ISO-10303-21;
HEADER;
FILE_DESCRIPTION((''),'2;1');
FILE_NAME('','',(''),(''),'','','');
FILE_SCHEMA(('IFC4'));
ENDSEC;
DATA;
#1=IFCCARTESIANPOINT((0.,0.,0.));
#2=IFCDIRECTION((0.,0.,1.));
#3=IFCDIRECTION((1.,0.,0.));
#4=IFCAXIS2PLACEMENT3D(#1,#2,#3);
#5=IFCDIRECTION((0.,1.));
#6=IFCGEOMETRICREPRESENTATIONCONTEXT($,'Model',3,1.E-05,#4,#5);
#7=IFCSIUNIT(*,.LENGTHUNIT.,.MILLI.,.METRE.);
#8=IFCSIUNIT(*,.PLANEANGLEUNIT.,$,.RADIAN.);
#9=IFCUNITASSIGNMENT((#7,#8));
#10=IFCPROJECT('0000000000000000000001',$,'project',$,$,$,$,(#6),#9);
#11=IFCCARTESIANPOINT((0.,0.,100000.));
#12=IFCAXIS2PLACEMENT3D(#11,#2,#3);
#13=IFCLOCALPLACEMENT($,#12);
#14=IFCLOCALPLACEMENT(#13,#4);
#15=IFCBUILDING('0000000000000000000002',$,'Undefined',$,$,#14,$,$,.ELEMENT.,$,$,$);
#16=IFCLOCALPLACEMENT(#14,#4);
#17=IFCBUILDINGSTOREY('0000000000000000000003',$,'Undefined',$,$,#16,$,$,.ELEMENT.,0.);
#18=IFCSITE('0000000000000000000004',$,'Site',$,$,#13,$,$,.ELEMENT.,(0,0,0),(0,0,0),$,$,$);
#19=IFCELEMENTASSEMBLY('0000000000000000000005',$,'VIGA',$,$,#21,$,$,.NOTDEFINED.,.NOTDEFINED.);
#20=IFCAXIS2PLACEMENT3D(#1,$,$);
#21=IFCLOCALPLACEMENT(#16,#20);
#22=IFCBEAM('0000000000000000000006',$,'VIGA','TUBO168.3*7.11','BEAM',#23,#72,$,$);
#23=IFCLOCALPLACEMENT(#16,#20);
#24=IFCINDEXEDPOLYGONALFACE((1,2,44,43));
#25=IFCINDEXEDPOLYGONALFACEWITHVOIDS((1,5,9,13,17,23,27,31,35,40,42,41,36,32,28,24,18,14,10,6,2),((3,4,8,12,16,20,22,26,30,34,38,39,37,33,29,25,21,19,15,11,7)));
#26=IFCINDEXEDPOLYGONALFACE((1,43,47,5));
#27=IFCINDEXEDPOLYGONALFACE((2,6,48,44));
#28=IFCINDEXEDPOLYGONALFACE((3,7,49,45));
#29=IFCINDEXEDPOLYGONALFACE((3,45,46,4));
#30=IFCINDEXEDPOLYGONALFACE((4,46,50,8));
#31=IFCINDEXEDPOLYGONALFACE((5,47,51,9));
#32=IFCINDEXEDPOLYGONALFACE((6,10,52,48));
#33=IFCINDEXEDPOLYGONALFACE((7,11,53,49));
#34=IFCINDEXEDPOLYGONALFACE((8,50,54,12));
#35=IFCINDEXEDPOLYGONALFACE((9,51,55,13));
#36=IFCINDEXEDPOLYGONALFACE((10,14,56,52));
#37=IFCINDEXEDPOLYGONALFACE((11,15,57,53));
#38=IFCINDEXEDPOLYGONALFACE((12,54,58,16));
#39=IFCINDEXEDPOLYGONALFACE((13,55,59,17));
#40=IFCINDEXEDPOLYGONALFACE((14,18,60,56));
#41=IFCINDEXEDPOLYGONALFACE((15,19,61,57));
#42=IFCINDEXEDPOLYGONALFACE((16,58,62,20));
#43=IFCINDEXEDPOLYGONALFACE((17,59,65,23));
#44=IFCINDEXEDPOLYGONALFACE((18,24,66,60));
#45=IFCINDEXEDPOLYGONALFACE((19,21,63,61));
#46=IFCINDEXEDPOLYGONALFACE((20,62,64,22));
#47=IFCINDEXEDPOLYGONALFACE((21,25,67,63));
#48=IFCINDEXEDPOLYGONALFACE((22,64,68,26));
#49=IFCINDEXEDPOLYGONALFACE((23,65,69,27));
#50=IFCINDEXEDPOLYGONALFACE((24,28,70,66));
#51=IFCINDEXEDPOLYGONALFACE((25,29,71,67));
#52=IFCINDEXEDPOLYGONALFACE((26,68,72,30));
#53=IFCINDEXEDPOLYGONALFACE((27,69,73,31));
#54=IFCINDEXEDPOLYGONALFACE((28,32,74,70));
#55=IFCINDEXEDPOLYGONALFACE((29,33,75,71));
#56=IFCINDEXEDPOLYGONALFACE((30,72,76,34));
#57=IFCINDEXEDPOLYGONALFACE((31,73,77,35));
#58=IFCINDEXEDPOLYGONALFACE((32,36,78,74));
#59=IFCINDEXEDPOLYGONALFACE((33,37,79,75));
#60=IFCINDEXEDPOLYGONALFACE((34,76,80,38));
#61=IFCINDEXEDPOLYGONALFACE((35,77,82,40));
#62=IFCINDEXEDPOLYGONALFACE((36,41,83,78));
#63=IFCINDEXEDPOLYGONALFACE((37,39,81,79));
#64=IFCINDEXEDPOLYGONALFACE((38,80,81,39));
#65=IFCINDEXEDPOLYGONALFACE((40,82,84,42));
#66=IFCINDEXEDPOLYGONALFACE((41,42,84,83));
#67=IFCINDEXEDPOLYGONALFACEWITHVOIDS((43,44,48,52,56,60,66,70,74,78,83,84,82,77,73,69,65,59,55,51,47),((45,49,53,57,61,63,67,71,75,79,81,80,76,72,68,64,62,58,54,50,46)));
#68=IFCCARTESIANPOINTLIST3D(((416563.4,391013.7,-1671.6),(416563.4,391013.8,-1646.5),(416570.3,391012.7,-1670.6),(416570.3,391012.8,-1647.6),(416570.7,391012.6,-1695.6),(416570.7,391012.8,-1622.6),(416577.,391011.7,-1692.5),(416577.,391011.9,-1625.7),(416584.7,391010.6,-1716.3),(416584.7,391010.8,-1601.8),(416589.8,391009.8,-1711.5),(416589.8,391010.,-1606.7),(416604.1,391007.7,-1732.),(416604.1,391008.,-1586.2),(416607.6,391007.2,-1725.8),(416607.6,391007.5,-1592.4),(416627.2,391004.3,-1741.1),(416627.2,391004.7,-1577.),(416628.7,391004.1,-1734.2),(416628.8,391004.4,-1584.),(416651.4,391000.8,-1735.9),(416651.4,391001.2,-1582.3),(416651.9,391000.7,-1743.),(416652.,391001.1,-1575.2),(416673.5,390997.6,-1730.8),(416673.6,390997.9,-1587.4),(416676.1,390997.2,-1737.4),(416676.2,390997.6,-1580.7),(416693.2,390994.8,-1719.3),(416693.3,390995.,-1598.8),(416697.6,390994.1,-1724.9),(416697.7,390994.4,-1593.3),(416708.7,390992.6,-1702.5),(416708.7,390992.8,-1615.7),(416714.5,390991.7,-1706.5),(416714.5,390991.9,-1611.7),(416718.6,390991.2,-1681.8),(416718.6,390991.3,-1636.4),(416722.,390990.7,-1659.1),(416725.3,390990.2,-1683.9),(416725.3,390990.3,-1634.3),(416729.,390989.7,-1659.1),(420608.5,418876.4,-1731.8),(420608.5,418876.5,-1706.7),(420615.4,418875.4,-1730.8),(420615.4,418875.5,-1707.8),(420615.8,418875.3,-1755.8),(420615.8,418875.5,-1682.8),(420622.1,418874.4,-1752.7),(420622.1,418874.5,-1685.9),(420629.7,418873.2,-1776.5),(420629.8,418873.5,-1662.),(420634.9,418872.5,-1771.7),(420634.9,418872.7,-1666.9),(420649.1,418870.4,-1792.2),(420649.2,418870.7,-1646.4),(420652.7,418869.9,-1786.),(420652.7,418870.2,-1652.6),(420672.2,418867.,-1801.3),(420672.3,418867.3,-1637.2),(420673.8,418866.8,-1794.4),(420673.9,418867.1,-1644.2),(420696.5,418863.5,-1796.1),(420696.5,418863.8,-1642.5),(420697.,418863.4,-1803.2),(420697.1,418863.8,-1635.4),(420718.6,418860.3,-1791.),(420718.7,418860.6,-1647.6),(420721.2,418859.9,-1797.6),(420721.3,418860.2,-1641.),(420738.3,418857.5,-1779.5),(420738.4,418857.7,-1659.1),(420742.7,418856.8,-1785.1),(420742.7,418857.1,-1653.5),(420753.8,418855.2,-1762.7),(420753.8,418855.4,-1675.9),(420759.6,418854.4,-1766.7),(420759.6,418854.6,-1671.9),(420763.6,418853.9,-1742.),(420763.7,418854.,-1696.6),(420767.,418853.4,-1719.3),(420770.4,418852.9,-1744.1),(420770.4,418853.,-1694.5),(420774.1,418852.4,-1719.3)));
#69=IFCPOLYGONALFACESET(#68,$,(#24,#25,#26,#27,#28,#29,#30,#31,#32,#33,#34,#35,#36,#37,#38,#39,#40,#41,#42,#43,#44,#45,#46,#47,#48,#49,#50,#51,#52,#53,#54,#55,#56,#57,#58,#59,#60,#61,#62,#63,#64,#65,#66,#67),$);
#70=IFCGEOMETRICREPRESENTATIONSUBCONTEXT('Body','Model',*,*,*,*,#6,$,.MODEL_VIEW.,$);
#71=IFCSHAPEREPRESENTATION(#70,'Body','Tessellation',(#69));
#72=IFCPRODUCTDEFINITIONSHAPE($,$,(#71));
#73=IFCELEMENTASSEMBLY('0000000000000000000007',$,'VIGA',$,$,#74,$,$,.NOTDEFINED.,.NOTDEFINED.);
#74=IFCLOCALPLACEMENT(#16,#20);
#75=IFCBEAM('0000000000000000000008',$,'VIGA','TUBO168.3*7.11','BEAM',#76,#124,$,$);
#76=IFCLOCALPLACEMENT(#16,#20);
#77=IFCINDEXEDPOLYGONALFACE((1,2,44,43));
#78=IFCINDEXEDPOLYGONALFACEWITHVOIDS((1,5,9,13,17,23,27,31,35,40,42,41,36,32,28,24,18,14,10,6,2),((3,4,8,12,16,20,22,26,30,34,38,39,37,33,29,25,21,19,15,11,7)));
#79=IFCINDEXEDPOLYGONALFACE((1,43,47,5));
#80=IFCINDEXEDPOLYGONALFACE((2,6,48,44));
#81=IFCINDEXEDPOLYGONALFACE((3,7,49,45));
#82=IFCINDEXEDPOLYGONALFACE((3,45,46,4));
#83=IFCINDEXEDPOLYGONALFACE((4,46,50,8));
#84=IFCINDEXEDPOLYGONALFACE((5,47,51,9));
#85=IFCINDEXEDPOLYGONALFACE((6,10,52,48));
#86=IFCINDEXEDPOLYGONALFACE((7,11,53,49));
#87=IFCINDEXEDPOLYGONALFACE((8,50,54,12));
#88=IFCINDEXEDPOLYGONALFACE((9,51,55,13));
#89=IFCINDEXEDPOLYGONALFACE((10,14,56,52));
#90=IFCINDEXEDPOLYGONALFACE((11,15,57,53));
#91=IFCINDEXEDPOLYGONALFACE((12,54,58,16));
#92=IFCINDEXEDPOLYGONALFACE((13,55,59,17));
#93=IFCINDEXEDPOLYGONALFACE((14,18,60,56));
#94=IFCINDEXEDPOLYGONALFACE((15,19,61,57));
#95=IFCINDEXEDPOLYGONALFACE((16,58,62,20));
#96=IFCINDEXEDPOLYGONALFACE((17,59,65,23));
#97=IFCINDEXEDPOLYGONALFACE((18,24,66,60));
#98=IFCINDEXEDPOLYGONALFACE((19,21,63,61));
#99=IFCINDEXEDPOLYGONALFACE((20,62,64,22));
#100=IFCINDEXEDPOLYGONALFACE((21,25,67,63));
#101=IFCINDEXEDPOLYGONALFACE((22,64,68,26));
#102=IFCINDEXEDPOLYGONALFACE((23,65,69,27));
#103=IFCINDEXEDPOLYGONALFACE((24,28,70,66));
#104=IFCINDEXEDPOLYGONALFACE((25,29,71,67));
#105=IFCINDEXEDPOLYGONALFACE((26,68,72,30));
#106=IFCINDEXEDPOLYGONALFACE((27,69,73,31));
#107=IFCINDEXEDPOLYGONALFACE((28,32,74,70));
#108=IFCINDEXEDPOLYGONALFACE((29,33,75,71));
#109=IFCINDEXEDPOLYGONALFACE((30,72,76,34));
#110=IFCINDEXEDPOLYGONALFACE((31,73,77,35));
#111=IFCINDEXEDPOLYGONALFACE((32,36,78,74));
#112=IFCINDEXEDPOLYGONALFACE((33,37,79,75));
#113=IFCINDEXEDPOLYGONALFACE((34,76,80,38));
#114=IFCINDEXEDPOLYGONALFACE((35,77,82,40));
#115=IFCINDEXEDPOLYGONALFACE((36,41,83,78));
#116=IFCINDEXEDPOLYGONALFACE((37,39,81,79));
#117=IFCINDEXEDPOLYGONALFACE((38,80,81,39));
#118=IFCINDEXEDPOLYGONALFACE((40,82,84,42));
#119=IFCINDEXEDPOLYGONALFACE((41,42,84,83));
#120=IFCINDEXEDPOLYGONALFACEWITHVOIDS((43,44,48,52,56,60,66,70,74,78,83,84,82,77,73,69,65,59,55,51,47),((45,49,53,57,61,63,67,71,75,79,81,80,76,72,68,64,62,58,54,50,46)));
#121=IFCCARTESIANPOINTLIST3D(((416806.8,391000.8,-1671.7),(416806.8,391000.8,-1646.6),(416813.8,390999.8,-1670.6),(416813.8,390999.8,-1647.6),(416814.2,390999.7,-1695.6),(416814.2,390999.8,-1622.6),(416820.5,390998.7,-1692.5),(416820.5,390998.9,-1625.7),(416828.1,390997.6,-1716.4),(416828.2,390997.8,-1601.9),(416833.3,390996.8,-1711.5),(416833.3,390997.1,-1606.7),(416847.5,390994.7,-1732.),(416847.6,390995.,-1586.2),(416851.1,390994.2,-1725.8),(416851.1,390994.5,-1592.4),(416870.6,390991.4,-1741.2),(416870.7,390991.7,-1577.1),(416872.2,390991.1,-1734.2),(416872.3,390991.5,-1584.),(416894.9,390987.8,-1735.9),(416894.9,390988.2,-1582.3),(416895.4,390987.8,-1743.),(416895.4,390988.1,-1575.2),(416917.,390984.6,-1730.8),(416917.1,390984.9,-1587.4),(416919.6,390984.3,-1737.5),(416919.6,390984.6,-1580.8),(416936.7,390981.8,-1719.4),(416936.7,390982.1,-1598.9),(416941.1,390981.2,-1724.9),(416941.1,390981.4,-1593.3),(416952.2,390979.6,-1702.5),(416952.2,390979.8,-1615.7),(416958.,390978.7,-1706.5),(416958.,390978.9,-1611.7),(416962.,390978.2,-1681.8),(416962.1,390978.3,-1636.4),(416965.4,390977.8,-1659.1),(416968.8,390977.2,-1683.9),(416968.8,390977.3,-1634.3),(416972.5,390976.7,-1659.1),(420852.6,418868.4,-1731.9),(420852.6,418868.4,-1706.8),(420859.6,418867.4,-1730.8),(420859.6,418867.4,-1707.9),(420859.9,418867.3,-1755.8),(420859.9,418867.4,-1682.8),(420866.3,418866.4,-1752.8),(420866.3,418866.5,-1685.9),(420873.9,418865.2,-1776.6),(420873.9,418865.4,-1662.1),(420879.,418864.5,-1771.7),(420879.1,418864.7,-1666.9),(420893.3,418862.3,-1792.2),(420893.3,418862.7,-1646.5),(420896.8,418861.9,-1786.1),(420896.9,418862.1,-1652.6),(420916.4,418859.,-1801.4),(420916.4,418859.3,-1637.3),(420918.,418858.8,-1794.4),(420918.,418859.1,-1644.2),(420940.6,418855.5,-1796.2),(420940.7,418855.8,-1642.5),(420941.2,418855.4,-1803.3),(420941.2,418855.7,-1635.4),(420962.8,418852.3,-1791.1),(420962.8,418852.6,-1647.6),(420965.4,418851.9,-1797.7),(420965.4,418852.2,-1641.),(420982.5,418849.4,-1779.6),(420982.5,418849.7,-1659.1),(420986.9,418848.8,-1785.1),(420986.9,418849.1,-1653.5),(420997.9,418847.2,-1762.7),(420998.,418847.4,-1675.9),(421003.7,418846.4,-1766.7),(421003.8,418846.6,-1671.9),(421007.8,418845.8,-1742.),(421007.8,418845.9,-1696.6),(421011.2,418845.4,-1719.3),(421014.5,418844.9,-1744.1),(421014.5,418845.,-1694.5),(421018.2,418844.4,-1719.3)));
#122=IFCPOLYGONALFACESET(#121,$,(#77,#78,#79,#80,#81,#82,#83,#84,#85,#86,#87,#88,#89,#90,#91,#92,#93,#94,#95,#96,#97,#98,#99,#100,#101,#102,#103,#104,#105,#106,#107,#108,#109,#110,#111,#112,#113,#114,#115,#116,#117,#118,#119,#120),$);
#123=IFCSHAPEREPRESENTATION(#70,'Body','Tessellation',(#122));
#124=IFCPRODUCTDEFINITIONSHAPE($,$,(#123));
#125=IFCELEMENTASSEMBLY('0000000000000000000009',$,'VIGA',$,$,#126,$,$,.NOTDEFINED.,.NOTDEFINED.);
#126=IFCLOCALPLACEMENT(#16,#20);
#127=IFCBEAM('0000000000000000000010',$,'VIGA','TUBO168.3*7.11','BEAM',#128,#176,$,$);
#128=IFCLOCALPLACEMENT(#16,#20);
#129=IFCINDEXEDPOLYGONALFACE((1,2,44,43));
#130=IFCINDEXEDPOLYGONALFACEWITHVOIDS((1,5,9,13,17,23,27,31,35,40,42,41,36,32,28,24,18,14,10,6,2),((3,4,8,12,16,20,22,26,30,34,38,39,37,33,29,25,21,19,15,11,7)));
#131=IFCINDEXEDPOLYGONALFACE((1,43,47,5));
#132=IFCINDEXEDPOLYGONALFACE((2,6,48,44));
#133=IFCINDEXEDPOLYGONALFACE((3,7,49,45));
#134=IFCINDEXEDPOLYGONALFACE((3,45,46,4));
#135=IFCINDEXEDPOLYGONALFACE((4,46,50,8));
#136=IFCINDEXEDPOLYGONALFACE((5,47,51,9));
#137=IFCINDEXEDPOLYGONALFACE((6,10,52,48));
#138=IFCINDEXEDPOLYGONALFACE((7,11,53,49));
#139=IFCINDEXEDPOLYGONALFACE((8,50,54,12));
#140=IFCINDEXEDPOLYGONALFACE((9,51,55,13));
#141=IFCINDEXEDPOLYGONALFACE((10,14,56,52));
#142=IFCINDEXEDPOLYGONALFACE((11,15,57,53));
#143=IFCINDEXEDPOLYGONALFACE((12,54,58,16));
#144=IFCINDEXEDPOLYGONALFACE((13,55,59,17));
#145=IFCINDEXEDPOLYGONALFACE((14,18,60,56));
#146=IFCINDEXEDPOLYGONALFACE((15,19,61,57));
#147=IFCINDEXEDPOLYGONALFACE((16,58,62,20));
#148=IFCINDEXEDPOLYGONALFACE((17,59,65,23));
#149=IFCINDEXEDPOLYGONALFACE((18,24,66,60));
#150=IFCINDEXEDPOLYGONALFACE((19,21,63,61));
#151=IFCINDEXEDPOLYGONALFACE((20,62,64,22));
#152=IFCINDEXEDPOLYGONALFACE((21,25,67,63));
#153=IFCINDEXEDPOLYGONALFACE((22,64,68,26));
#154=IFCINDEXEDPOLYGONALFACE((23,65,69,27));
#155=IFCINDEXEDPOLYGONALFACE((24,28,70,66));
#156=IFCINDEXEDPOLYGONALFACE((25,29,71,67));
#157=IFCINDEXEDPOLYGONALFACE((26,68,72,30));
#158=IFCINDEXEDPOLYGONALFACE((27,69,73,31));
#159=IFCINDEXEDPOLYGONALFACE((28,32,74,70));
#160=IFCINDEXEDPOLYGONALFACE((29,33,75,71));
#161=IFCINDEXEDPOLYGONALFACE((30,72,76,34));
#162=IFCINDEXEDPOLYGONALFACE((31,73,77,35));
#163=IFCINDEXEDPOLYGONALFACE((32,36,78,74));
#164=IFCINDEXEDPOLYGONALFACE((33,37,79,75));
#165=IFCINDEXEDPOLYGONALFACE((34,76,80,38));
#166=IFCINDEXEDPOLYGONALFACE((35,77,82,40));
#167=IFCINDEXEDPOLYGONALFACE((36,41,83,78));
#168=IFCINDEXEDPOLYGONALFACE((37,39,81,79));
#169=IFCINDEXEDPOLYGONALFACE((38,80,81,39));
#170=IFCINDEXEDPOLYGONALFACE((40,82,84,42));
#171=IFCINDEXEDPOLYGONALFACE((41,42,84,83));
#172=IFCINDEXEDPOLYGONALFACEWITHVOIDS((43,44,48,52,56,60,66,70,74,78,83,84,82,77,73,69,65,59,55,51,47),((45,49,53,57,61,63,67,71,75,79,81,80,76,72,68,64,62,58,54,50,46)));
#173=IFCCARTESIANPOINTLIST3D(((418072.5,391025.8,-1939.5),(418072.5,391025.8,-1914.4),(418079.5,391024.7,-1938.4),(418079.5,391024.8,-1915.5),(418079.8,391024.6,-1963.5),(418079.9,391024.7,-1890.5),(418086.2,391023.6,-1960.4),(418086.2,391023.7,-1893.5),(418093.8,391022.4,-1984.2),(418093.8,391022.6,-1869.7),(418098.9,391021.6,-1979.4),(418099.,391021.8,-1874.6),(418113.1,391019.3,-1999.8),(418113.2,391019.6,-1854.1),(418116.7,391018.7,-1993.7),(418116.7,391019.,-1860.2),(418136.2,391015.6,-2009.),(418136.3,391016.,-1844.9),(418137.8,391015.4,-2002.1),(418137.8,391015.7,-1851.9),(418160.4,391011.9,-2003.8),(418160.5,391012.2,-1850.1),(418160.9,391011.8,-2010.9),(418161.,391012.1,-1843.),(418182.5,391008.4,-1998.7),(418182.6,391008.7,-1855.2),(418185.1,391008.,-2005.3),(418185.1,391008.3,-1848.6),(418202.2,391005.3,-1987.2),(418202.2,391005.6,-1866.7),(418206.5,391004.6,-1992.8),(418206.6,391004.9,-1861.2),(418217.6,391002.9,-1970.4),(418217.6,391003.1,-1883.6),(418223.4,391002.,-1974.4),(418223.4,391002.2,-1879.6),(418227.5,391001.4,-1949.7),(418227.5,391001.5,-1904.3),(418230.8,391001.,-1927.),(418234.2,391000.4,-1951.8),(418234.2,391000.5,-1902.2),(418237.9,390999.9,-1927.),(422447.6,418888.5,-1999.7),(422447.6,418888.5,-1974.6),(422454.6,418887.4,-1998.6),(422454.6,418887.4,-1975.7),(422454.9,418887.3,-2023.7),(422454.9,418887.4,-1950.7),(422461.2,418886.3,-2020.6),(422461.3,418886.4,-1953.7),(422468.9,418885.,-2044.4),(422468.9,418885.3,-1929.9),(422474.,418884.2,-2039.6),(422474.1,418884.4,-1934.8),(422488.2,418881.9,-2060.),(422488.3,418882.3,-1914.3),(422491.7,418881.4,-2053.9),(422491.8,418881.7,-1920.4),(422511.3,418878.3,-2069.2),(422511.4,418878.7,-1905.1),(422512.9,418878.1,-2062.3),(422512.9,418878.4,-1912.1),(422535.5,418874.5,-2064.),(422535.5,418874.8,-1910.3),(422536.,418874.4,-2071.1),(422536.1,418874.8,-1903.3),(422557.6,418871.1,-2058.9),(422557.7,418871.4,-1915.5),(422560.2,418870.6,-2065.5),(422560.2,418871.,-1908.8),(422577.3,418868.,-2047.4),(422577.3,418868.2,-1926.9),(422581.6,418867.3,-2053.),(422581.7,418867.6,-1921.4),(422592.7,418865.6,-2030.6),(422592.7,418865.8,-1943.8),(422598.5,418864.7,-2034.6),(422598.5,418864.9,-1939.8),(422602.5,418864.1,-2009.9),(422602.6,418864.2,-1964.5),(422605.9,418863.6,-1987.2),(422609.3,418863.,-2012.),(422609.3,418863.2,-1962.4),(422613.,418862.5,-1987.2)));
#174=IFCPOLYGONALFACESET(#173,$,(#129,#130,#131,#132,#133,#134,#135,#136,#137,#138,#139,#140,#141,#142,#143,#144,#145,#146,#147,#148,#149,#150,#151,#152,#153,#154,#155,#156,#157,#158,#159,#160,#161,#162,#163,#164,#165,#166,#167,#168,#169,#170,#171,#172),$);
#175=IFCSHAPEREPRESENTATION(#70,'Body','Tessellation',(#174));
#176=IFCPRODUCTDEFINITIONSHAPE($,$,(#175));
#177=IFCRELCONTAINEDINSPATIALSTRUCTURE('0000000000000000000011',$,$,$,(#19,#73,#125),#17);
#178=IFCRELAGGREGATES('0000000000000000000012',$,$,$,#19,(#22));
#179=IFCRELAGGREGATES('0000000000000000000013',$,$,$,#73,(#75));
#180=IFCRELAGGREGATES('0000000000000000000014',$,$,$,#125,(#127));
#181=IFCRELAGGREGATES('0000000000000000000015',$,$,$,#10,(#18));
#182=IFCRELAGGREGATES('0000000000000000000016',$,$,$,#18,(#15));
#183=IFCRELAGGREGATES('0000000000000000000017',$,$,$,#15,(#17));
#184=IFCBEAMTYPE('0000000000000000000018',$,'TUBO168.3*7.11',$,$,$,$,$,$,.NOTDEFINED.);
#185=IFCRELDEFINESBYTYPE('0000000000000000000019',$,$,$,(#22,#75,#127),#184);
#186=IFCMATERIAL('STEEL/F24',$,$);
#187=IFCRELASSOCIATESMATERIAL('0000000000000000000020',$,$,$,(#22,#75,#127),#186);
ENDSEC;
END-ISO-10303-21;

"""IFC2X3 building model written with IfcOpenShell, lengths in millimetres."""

from ifc_helpers import new_model, si_unit, direction, frame, origin_with_axes, origin_2d_with_axis, place, context, subcontext, project, spatial, hollow_circle, extrude, material, type_object, element, aggregate, save


model = new_model("IFC2X3")

# Units and contexts
model_context = context("Model", 3, precision=1e-05, world=origin_with_axes(), true_north=direction((0.0, 1.0)))
body_context = subcontext(model_context, "Body", "Model", "MODEL_VIEW")
ifc_project = project(units=[si_unit("LENGTHUNIT", "METRE", prefix="MILLI"), si_unit("PLANEANGLEUNIT", "RADIAN")], contexts=[model_context])

# Site, building, storey
site_placement = place(None, frame((0.0, 0.0, 100000.0), z_axis=(0.0, 0.0, 1.0), x_axis=(1.0, 0.0, 0.0)))
site = spatial("IfcSite", under=ifc_project, at=site_placement, Name="Site", CompositionType="ELEMENT", RefLatitude=(0, 0, 0), RefLongitude=(0, 0, 0))
building_placement = place(site_placement, origin_with_axes())
building = spatial("IfcBuilding", under=site, at=building_placement, Name="Undefined", CompositionType="ELEMENT")
storey_placement = place(building_placement, origin_with_axes())
storey = spatial("IfcBuildingStorey", under=building, at=storey_placement, Name="Undefined", CompositionType="ELEMENT", Elevation=0.0)

# Element assemblies, beams
ifc_material_1 = material(Name="STEEL/F24")
beam_type_1 = type_object("IfcBeamType", Name="TUBO168.3*7.11", PredefinedType="NOTDEFINED")
assembly_1_placement = place(storey_placement, origin_with_axes())
assembly_1 = element("IfcElementAssembly", 1, at=assembly_1_placement, inside=storey, Name="VIGA", AssemblyPlace="NOTDEFINED", PredefinedType="NOTDEFINED")
beam_1_placement = place(assembly_1_placement, frame((416645.7, 391001.8, -1659.1), z_axis=(0.000307, 0.002116, 0.999998), x_axis=(0.143673, 0.989623, -0.002138)))
beam_1 = element("IfcBeam", 2, at=beam_1_placement, type_object=beam_type_1, material=ifc_material_1, Name="VIGA", Description="TUBO168.3*7.11", ObjectType="BEAM", context=body_context, shape_type="SweptSolid", body=[
    extrude(hollow_circle(Radius=84.2, WallThickness=7.1, at=origin_2d_with_axis()), frame((28154.8, 0.0, 0.0), z_axis=(-1.0, 0.0, 0.0), x_axis=(0.0, -1.0, 0.0)), (0.0, 0.0, 1.0), 28154.8),
])
aggregate(assembly_1, [beam_1])
assembly_2_placement = place(storey_placement, origin_with_axes())
assembly_2 = element("IfcElementAssembly", 3, at=assembly_2_placement, inside=storey, Name="VIGA", AssemblyPlace="NOTDEFINED", PredefinedType="NOTDEFINED")
beam_2_placement = place(assembly_2_placement, frame((416889.2, 390988.8, -1659.1), z_axis=(0.000307, 0.002116, 0.999998), x_axis=(0.143671, 0.989623, -0.002138)))
beam_2 = element("IfcBeam", 4, at=beam_2_placement, type_object=beam_type_1, material=ifc_material_1, Name="VIGA", Description="TUBO168.3*7.11", ObjectType="BEAM", context=body_context, shape_type="SweptSolid", body=[
    extrude(hollow_circle(Radius=84.2, WallThickness=7.1, at=origin_2d_with_axis()), frame((28159.8, 0.0, 0.0), z_axis=(-1.0, 0.0, 0.0), x_axis=(0.0, -1.0, 0.0)), (0.0, 0.0, 1.0), 28159.8),
])
aggregate(assembly_2, [beam_2])
assembly_3_placement = place(storey_placement, origin_with_axes())
assembly_3 = element("IfcElementAssembly", 5, at=assembly_3_placement, inside=storey, Name="VIGA", AssemblyPlace="NOTDEFINED", PredefinedType="NOTDEFINED")
beam_3_placement = place(assembly_3_placement, frame((418154.7, 391012.9, -1927.0), z_axis=(0.000331, 0.002109, 0.999998), x_axis=(0.155122, 0.987893, -0.002135)))
beam_3 = element("IfcBeam", 6, at=beam_3_placement, type_object=beam_type_1, material=ifc_material_1, Name="VIGA", Description="TUBO168.3*7.11", ObjectType="BEAM", context=body_context, shape_type="SweptSolid", body=[
    extrude(hollow_circle(Radius=84.2, WallThickness=7.1, at=origin_2d_with_axis()), frame((28204.1, 0.0, 0.0), z_axis=(-1.0, 0.0, 0.0), x_axis=(0.0, -1.0, 0.0)), (0.0, 0.0, 1.0), 28204.1),
])
aggregate(assembly_3, [beam_3])

save(model, "model.ifc")
